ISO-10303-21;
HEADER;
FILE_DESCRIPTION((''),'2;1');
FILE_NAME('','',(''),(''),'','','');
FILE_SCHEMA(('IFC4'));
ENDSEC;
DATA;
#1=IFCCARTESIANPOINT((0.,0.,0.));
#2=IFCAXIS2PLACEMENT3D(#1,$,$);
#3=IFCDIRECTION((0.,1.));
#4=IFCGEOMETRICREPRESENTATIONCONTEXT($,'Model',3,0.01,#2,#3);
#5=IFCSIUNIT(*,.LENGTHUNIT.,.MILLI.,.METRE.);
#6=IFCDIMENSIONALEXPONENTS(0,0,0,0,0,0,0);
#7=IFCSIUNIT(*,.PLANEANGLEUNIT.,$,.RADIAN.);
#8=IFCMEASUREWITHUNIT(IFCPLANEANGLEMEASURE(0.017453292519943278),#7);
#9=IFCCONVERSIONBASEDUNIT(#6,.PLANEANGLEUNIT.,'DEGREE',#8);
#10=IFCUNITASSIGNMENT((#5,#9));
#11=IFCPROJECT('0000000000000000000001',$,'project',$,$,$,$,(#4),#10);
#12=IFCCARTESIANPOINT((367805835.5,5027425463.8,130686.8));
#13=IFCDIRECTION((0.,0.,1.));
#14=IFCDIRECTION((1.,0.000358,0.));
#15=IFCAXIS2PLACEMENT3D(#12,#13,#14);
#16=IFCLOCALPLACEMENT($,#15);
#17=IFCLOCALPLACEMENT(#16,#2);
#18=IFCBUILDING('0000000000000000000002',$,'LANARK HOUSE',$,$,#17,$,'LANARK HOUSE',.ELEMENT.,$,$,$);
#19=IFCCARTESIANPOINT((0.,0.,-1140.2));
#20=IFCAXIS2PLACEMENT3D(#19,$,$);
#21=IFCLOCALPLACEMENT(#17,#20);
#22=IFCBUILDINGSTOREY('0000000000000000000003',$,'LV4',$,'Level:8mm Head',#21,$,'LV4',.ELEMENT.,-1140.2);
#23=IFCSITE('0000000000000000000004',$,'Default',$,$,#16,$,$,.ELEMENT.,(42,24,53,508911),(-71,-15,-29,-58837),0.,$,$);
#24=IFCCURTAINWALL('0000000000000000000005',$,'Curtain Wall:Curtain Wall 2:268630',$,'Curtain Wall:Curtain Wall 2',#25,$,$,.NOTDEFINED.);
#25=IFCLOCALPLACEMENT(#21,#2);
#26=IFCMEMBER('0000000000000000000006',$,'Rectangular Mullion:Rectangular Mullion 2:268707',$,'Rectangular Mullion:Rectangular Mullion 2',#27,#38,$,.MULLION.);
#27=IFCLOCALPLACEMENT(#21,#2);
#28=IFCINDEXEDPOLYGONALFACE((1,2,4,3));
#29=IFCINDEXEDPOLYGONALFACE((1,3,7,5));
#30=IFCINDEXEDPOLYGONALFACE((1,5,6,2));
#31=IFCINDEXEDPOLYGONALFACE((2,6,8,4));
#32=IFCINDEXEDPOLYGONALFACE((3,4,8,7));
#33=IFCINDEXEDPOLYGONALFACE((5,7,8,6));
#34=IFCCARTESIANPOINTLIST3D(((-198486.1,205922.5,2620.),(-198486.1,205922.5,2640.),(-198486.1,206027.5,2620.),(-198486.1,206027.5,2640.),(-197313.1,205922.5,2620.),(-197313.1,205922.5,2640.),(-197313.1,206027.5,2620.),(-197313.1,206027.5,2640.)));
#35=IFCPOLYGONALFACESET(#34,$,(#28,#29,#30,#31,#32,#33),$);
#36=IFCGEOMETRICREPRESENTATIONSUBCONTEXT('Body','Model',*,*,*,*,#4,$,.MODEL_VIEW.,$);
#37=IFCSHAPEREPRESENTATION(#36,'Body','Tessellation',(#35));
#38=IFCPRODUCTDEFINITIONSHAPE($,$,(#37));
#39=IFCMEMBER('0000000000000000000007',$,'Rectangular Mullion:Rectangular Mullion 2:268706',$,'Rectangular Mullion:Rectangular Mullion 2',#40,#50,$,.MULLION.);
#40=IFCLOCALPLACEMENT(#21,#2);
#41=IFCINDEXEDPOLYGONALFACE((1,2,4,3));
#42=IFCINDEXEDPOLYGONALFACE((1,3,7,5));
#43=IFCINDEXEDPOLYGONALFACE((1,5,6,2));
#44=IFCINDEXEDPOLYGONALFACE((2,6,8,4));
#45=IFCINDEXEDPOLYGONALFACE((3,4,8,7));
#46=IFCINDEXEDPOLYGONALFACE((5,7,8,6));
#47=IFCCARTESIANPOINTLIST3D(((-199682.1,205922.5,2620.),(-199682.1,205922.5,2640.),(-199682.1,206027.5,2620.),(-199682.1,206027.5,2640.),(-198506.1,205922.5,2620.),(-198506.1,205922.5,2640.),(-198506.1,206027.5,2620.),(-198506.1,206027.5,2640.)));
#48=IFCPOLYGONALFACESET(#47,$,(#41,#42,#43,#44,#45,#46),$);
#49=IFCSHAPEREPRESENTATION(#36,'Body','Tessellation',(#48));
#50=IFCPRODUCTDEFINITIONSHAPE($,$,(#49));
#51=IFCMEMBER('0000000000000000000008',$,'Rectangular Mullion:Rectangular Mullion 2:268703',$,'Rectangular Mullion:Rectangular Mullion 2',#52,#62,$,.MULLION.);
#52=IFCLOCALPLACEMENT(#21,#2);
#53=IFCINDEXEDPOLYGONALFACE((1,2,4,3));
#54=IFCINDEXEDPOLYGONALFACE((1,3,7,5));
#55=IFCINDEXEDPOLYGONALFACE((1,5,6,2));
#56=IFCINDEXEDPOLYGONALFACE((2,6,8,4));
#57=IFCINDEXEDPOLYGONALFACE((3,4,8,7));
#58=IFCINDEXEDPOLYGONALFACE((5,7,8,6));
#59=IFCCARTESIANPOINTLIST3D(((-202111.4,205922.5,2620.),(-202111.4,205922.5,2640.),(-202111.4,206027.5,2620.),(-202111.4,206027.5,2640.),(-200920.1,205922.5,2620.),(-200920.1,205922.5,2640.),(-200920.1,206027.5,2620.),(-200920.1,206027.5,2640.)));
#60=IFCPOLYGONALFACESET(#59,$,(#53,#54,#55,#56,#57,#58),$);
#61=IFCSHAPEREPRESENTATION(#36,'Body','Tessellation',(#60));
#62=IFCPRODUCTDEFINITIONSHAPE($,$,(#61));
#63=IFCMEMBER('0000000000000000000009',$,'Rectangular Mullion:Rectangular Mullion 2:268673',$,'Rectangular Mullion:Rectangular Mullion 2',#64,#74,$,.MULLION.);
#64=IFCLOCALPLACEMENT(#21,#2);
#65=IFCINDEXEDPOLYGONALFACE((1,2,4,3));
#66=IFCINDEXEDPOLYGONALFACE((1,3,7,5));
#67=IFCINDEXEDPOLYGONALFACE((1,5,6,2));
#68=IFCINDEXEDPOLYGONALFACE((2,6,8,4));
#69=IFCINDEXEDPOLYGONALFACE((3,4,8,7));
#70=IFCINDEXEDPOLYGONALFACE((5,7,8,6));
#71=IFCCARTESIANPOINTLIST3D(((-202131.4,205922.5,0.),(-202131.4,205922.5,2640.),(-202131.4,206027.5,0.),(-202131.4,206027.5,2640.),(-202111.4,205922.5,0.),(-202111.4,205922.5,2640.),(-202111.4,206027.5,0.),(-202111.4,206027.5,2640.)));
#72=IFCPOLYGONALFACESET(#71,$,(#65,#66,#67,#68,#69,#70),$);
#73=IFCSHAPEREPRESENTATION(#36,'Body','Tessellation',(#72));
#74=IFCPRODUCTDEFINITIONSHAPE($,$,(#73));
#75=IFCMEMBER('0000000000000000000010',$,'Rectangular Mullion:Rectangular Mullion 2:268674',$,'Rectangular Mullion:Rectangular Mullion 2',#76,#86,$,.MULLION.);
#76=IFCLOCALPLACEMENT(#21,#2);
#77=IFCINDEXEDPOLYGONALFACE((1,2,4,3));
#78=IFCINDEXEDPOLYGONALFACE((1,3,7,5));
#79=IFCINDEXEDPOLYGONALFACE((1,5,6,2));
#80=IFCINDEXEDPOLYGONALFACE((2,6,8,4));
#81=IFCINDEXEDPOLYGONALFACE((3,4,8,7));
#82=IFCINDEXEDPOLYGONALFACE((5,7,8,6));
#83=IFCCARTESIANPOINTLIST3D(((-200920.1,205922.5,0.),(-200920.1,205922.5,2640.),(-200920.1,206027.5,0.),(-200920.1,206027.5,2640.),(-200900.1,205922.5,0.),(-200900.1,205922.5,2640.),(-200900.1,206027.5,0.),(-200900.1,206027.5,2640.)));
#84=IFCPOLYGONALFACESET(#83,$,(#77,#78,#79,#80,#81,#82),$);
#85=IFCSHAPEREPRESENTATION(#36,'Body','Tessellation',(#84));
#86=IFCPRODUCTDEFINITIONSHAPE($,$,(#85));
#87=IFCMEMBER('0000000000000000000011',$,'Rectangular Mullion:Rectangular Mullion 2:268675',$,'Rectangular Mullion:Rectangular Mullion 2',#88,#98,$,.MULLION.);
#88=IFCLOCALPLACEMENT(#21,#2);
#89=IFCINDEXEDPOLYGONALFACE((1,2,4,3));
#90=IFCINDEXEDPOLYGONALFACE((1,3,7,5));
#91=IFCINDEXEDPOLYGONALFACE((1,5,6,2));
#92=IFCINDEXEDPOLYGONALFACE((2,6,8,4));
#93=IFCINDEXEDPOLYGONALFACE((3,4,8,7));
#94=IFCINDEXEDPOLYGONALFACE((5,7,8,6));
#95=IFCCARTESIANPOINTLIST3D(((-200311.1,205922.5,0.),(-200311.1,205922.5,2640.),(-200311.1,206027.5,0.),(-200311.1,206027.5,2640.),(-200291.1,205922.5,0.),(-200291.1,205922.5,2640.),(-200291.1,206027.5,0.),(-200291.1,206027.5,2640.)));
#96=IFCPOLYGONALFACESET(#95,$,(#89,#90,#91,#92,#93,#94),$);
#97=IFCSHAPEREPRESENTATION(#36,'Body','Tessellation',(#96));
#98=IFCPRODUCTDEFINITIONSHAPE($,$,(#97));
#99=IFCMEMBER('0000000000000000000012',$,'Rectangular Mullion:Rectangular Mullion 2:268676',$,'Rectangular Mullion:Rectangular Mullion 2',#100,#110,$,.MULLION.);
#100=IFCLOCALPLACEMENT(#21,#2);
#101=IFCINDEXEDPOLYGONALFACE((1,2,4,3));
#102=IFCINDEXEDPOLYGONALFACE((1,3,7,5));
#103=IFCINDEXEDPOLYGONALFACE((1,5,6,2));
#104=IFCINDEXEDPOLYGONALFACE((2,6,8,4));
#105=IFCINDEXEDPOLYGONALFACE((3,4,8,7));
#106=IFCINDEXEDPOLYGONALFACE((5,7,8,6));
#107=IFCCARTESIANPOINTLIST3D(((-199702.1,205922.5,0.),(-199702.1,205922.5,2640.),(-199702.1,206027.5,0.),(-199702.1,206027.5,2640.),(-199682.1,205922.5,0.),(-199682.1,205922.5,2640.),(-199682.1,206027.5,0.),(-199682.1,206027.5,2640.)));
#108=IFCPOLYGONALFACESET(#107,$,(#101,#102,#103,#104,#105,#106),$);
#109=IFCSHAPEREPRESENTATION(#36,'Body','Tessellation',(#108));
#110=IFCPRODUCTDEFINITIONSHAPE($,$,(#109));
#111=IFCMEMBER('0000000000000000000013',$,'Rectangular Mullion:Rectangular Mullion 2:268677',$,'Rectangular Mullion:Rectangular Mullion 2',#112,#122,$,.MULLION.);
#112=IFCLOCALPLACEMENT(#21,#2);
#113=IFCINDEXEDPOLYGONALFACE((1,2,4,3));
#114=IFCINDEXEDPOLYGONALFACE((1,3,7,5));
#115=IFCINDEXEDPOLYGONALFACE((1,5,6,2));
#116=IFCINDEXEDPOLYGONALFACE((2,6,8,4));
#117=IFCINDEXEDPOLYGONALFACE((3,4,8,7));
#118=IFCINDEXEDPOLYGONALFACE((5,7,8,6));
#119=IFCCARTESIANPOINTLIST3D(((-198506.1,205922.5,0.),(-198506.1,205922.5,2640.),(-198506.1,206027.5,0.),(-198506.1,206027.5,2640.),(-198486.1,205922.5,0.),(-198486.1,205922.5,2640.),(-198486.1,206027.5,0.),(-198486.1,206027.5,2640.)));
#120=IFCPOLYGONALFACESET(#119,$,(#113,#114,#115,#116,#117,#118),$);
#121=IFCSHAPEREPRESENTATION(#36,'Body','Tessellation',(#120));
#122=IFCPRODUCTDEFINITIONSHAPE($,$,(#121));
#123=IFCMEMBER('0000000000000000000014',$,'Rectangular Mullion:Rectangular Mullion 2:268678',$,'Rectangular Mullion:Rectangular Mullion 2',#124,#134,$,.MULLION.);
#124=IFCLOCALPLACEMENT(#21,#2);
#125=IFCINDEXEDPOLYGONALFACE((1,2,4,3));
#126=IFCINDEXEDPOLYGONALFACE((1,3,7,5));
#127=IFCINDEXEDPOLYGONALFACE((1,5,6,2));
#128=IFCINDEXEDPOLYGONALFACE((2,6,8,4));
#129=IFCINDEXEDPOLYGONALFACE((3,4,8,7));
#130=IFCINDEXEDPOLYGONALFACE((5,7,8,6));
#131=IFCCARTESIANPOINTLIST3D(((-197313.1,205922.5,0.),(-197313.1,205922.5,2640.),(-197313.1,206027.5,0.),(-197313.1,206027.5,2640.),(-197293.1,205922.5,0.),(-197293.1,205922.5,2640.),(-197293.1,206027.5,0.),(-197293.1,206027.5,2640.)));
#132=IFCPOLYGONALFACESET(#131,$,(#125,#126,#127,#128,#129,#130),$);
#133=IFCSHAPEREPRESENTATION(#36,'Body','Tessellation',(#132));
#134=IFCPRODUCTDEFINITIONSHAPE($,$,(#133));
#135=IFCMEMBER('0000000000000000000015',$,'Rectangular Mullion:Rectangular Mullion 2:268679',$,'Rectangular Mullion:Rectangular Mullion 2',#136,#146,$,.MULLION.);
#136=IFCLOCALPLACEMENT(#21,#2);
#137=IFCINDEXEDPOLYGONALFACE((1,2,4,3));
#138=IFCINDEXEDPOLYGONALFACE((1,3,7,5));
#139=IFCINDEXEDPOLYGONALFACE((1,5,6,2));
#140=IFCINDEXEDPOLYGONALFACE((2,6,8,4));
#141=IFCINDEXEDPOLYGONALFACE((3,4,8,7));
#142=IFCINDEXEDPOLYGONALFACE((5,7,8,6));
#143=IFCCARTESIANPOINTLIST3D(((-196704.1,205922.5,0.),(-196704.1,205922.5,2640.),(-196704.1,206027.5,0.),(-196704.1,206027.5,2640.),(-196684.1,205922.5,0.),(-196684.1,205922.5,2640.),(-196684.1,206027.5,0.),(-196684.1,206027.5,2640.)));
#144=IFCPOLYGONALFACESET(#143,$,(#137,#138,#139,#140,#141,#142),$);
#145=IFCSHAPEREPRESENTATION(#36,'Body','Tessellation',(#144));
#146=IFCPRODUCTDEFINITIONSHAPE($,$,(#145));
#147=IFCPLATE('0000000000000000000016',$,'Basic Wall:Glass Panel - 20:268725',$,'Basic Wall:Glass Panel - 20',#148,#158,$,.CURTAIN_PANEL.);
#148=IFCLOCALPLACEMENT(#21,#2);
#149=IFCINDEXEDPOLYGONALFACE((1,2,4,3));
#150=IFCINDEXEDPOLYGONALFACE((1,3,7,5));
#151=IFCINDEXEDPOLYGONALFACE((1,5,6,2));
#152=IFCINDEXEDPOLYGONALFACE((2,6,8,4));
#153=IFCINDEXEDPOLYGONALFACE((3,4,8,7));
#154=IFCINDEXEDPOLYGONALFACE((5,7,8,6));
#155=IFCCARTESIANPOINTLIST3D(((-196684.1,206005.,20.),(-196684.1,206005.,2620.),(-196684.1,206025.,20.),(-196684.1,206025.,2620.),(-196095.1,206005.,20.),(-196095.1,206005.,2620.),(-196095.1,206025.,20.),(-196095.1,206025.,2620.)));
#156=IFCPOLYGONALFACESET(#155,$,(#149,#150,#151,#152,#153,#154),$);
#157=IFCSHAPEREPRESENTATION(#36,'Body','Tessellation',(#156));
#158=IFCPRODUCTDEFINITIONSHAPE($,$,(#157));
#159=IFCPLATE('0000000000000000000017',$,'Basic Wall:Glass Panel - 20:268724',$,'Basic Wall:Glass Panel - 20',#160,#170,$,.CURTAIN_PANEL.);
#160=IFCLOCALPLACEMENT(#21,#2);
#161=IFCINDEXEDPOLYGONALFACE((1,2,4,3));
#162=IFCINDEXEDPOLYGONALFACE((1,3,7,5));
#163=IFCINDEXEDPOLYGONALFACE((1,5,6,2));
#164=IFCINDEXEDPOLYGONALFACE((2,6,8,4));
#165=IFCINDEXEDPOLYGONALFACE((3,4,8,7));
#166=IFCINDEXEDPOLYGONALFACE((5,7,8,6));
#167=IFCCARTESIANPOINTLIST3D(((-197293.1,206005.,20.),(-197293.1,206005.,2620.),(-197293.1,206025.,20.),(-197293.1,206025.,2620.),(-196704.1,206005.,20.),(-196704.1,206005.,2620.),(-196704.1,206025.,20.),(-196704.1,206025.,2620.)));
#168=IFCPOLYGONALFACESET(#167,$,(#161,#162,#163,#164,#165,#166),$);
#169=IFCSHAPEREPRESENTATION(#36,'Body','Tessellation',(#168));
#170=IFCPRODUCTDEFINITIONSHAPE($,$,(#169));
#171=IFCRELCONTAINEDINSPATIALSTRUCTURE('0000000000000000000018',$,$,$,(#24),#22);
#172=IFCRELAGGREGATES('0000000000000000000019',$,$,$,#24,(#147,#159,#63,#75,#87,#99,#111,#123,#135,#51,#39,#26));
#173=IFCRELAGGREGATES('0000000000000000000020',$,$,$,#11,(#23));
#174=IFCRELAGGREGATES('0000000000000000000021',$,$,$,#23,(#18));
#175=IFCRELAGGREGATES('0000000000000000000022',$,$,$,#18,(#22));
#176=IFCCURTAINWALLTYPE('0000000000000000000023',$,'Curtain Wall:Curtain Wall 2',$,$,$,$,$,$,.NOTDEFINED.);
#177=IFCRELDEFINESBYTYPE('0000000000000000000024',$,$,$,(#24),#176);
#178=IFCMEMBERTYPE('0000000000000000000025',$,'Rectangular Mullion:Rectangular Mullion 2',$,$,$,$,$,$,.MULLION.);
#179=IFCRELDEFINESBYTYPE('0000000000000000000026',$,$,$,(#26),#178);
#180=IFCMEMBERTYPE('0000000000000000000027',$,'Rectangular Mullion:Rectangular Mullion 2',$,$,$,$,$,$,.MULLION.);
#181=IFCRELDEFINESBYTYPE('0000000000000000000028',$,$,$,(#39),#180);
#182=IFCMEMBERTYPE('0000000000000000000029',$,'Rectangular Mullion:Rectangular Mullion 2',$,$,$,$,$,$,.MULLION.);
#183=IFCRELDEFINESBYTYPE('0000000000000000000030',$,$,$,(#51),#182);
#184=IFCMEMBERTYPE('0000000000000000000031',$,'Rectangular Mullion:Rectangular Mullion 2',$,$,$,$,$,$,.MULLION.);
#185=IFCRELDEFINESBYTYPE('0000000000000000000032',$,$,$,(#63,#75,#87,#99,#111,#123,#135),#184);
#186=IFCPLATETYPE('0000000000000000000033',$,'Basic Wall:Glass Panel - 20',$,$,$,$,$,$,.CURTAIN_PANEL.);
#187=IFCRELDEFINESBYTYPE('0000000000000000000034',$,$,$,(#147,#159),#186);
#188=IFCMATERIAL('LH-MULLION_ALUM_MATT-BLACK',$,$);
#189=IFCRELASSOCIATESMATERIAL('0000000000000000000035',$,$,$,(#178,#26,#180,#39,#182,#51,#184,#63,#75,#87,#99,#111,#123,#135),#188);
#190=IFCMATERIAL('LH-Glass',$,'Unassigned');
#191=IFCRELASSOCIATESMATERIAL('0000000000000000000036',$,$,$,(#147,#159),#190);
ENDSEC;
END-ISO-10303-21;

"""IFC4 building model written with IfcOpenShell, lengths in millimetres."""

from ifc_helpers import new_model, entity, si_unit, converted_unit, direction, frame, origin, place, context, subcontext, project, spatial, indexed_curve, outline, extrude, source, transform, mapped, material, type_object, type_shapes, element, aggregate, save


model = new_model("IFC4")

# Units and contexts
model_context = context("Model", 3, precision=0.01, world=origin(), true_north=direction((0.0, 1.0)))
body_context = subcontext(model_context, "Body", "Model", "MODEL_VIEW")
ifc_project = project(units=[si_unit("LENGTHUNIT", "METRE", prefix="MILLI"), converted_unit("PLANEANGLEUNIT", "DEGREE", entity("IfcPlaneAngleMeasure", 0.017453292519943278), si_unit("PLANEANGLEUNIT", "RADIAN"), dimensions=[0, 0, 0, 0, 0, 0, 0])], contexts=[model_context])

# Site, building, storey
site_placement = place(None, frame((367805835.5, 5027425463.8, 130686.8), z_axis=(0.0, 0.0, 1.0), x_axis=(1.0, 0.000358, 0.0)))
site = spatial("IfcSite", under=ifc_project, at=site_placement, Name="Default", CompositionType="ELEMENT", RefLatitude=(42, 24, 53, 508911), RefLongitude=(-71, -15, -29, -58837), RefElevation=0.0)
building_placement = place(site_placement, origin())
building = spatial("IfcBuilding", under=site, at=building_placement, Name="LANARK HOUSE", LongName="LANARK HOUSE", CompositionType="ELEMENT")
storey_placement = place(building_placement, frame((0.0, 0.0, -1140.2)))
storey = spatial("IfcBuildingStorey", under=building, at=storey_placement, Name="LV4", ObjectType="Level:8mm Head", LongName="LV4", CompositionType="ELEMENT", Elevation=-1140.2)

# Curtain wall, members, plates
curtain_wall_type = type_object("IfcCurtainWallType", Name="Curtain Wall:Curtain Wall 2", PredefinedType="NOTDEFINED")
curtain_wall_placement = place(storey_placement, frame((0.0, 0.0, 1140.2)))
curtain_wall = element("IfcCurtainWall", 1, at=curtain_wall_placement, inside=storey, type_object=curtain_wall_type, Name="Curtain Wall:Curtain Wall 2:268630", ObjectType="Curtain Wall:Curtain Wall 2", PredefinedType="NOTDEFINED")
ifc_material_1 = material(Name="LH-MULLION_ALUM_MATT-BLACK")
member_type_1 = type_object("IfcMemberType", Name="Rectangular Mullion:Rectangular Mullion 2", PredefinedType="MULLION", material=ifc_material_1)
shared_shape_1 = source(origin(), body_context, "Body", "SweptSolid", [
    extrude(outline(indexed_curve([(-10.0, -52.5), (10.0, -52.5), (10.0, 52.5), (-10.0, 52.5), (-10.0, -52.5)], self_intersect=False)), frame((-10.0, -40.0, -1173.0), z_axis=(0.0, 0.0, 1.0), x_axis=(-1.0, 0.0, 0.0)), (0.0, 0.0, 1.0), 1173.0),
])
type_shapes(member_type_1, [shared_shape_1])
member_1_placement = place(curtain_wall_placement, frame((-198486.1, 206015.0, 1499.8), z_axis=(-1.0, 0.0, 0.0), x_axis=(0.0, 0.0, 1.0)))
member_1 = element("IfcMember", 2, at=member_1_placement, type_object=member_type_1, material=ifc_material_1, Name="Rectangular Mullion:Rectangular Mullion 2:268707", ObjectType="Rectangular Mullion:Rectangular Mullion 2", PredefinedType="MULLION", context=body_context, shape_type="MappedRepresentation", body=[
    mapped(shared_shape_1, transform((0.0, 0.0, 0.0), scale=1.0)),
])
member_type_2 = type_object("IfcMemberType", Name="Rectangular Mullion:Rectangular Mullion 2", PredefinedType="MULLION", material=ifc_material_1)
shared_shape_2 = source(origin(), body_context, "Body", "SweptSolid", [
    extrude(outline(indexed_curve([(-10.0, -52.5), (10.0, -52.5), (10.0, 52.5), (-10.0, 52.5), (-10.0, -52.5)], self_intersect=False)), frame((-10.0, -40.0, -1176.0), z_axis=(0.0, 0.0, 1.0), x_axis=(-1.0, 0.0, 0.0)), (0.0, 0.0, 1.0), 1176.0),
])
type_shapes(member_type_2, [shared_shape_2])
member_2_placement = place(curtain_wall_placement, frame((-199682.1, 206015.0, 1499.8), z_axis=(-1.0, 0.0, 0.0), x_axis=(0.0, 0.0, 1.0)))
member_2 = element("IfcMember", 3, at=member_2_placement, type_object=member_type_2, material=ifc_material_1, Name="Rectangular Mullion:Rectangular Mullion 2:268706", ObjectType="Rectangular Mullion:Rectangular Mullion 2", PredefinedType="MULLION", context=body_context, shape_type="MappedRepresentation", body=[
    mapped(shared_shape_2, transform((0.0, 0.0, 0.0), scale=1.0)),
])
member_type_3 = type_object("IfcMemberType", Name="Rectangular Mullion:Rectangular Mullion 2", PredefinedType="MULLION", material=ifc_material_1)
shared_shape_3 = source(origin(), body_context, "Body", "SweptSolid", [
    extrude(outline(indexed_curve([(-10.0, -52.5), (10.0, -52.5), (10.0, 52.5), (-10.0, 52.5), (-10.0, -52.5)], self_intersect=False)), frame((-10.0, -40.0, -1191.3), z_axis=(0.0, 0.0, 1.0), x_axis=(-1.0, 0.0, 0.0)), (0.0, 0.0, 1.0), 1191.3),
])
type_shapes(member_type_3, [shared_shape_3])
member_3_placement = place(curtain_wall_placement, frame((-202111.4, 206015.0, 1499.8), z_axis=(-1.0, 0.0, 0.0), x_axis=(0.0, 0.0, 1.0)))
member_3 = element("IfcMember", 4, at=member_3_placement, type_object=member_type_3, material=ifc_material_1, Name="Rectangular Mullion:Rectangular Mullion 2:268703", ObjectType="Rectangular Mullion:Rectangular Mullion 2", PredefinedType="MULLION", context=body_context, shape_type="MappedRepresentation", body=[
    mapped(shared_shape_3, transform((0.0, 0.0, 0.0), scale=1.0)),
])
member_type_4 = type_object("IfcMemberType", Name="Rectangular Mullion:Rectangular Mullion 2", PredefinedType="MULLION", material=ifc_material_1)
shared_shape_4 = source(origin(), body_context, "Body", "SweptSolid", [
    extrude(outline(indexed_curve([(-10.0, -52.5), (10.0, -52.5), (10.0, 52.5), (-10.0, 52.5), (-10.0, -52.5)], self_intersect=False)), frame((0.0, -40.0, -2640.0), z_axis=(0.0, 0.0, 1.0), x_axis=(-1.0, 0.0, 0.0)), (0.0, 0.0, 1.0), 2640.0),
])
type_shapes(member_type_4, [shared_shape_4])
member_4_placement = place(curtain_wall_placement, frame((-202121.4, 206015.0, -1140.2), z_axis=(0.0, 0.0, -1.0), x_axis=(-1.0, 0.0, 0.0)))
member_4 = element("IfcMember", 5, at=member_4_placement, type_object=member_type_4, material=ifc_material_1, Name="Rectangular Mullion:Rectangular Mullion 2:268673", ObjectType="Rectangular Mullion:Rectangular Mullion 2", PredefinedType="MULLION", context=body_context, shape_type="MappedRepresentation", body=[
    mapped(shared_shape_4, transform((0.0, 0.0, 0.0), scale=1.0)),
])
member_5_placement = place(curtain_wall_placement, frame((-200910.1, 206015.0, -1140.2), z_axis=(0.0, 0.0, -1.0), x_axis=(-1.0, 0.0, 0.0)))
member_5 = element("IfcMember", 6, at=member_5_placement, type_object=member_type_4, material=ifc_material_1, Name="Rectangular Mullion:Rectangular Mullion 2:268674", ObjectType="Rectangular Mullion:Rectangular Mullion 2", PredefinedType="MULLION", context=body_context, shape_type="MappedRepresentation", body=[
    mapped(shared_shape_4, transform((0.0, 0.0, 0.0), scale=1.0)),
])
member_6_placement = place(curtain_wall_placement, frame((-200301.1, 206015.0, -1140.2), z_axis=(0.0, 0.0, -1.0), x_axis=(-1.0, 0.0, 0.0)))
member_6 = element("IfcMember", 7, at=member_6_placement, type_object=member_type_4, material=ifc_material_1, Name="Rectangular Mullion:Rectangular Mullion 2:268675", ObjectType="Rectangular Mullion:Rectangular Mullion 2", PredefinedType="MULLION", context=body_context, shape_type="MappedRepresentation", body=[
    mapped(shared_shape_4, transform((0.0, 0.0, 0.0), scale=1.0)),
])
member_7_placement = place(curtain_wall_placement, frame((-199692.1, 206015.0, -1140.2), z_axis=(0.0, 0.0, -1.0), x_axis=(-1.0, 0.0, 0.0)))
member_7 = element("IfcMember", 8, at=member_7_placement, type_object=member_type_4, material=ifc_material_1, Name="Rectangular Mullion:Rectangular Mullion 2:268676", ObjectType="Rectangular Mullion:Rectangular Mullion 2", PredefinedType="MULLION", context=body_context, shape_type="MappedRepresentation", body=[
    mapped(shared_shape_4, transform((0.0, 0.0, 0.0), scale=1.0)),
])
member_8_placement = place(curtain_wall_placement, frame((-198496.1, 206015.0, -1140.2), z_axis=(0.0, 0.0, -1.0), x_axis=(-1.0, 0.0, 0.0)))
member_8 = element("IfcMember", 9, at=member_8_placement, type_object=member_type_4, material=ifc_material_1, Name="Rectangular Mullion:Rectangular Mullion 2:268677", ObjectType="Rectangular Mullion:Rectangular Mullion 2", PredefinedType="MULLION", context=body_context, shape_type="MappedRepresentation", body=[
    mapped(shared_shape_4, transform((0.0, 0.0, 0.0), scale=1.0)),
])
member_9_placement = place(curtain_wall_placement, frame((-197303.1, 206015.0, -1140.2), z_axis=(0.0, 0.0, -1.0), x_axis=(-1.0, 0.0, 0.0)))
member_9 = element("IfcMember", 10, at=member_9_placement, type_object=member_type_4, material=ifc_material_1, Name="Rectangular Mullion:Rectangular Mullion 2:268678", ObjectType="Rectangular Mullion:Rectangular Mullion 2", PredefinedType="MULLION", context=body_context, shape_type="MappedRepresentation", body=[
    mapped(shared_shape_4, transform((0.0, 0.0, 0.0), scale=1.0)),
])
member_10_placement = place(curtain_wall_placement, frame((-196694.1, 206015.0, -1140.2), z_axis=(0.0, 0.0, -1.0), x_axis=(-1.0, 0.0, 0.0)))
member_10 = element("IfcMember", 11, at=member_10_placement, type_object=member_type_4, material=ifc_material_1, Name="Rectangular Mullion:Rectangular Mullion 2:268679", ObjectType="Rectangular Mullion:Rectangular Mullion 2", PredefinedType="MULLION", context=body_context, shape_type="MappedRepresentation", body=[
    mapped(shared_shape_4, transform((0.0, 0.0, 0.0), scale=1.0)),
])
ifc_material_2 = material(Name="LH-Glass", Category="Unassigned")
plate_type = type_object("IfcPlateType", Name="Basic Wall:Glass Panel - 20", PredefinedType="CURTAIN_PANEL")
plate_1_placement = place(storey_placement, frame((-196095.1, 206015.0, 20.0), z_axis=(0.0, 0.0, 1.0), x_axis=(-1.0, 0.0, 0.0)))
plate_1 = element("IfcPlate", 12, at=plate_1_placement, type_object=plate_type, material=ifc_material_2, Name="Basic Wall:Glass Panel - 20:268725", ObjectType="Basic Wall:Glass Panel - 20", PredefinedType="CURTAIN_PANEL", context=body_context, shape_type="SweptSolid", body=[
    extrude(outline(indexed_curve([(-10.0, -294.5), (10.0, -294.5), (10.0, 294.5), (-10.0, 294.5), (-10.0, -294.5)], self_intersect=False)), frame((294.5, 0.0, 0.0), z_axis=(0.0, 0.0, 1.0), x_axis=(0.0, 1.0, 0.0)), (0.0, 0.0, 1.0), 2600.0),
])
plate_2_placement = place(storey_placement, frame((-196704.1, 206015.0, 20.0), z_axis=(0.0, 0.0, 1.0), x_axis=(-1.0, 0.0, 0.0)))
plate_2 = element("IfcPlate", 13, at=plate_2_placement, type_object=plate_type, material=ifc_material_2, Name="Basic Wall:Glass Panel - 20:268724", ObjectType="Basic Wall:Glass Panel - 20", PredefinedType="CURTAIN_PANEL", context=body_context, shape_type="SweptSolid", body=[
    extrude(outline(indexed_curve([(-10.0, -294.5), (10.0, -294.5), (10.0, 294.5), (-10.0, 294.5), (-10.0, -294.5)], self_intersect=False)), frame((294.5, 0.0, 0.0), z_axis=(0.0, 0.0, 1.0), x_axis=(0.0, 1.0, 0.0)), (0.0, 0.0, 1.0), 2600.0),
])
aggregate(curtain_wall, [plate_1, plate_2, member_4, member_5, member_6, member_7, member_8, member_9, member_10, member_3, member_2, member_1])

save(model, "model.ifc")
